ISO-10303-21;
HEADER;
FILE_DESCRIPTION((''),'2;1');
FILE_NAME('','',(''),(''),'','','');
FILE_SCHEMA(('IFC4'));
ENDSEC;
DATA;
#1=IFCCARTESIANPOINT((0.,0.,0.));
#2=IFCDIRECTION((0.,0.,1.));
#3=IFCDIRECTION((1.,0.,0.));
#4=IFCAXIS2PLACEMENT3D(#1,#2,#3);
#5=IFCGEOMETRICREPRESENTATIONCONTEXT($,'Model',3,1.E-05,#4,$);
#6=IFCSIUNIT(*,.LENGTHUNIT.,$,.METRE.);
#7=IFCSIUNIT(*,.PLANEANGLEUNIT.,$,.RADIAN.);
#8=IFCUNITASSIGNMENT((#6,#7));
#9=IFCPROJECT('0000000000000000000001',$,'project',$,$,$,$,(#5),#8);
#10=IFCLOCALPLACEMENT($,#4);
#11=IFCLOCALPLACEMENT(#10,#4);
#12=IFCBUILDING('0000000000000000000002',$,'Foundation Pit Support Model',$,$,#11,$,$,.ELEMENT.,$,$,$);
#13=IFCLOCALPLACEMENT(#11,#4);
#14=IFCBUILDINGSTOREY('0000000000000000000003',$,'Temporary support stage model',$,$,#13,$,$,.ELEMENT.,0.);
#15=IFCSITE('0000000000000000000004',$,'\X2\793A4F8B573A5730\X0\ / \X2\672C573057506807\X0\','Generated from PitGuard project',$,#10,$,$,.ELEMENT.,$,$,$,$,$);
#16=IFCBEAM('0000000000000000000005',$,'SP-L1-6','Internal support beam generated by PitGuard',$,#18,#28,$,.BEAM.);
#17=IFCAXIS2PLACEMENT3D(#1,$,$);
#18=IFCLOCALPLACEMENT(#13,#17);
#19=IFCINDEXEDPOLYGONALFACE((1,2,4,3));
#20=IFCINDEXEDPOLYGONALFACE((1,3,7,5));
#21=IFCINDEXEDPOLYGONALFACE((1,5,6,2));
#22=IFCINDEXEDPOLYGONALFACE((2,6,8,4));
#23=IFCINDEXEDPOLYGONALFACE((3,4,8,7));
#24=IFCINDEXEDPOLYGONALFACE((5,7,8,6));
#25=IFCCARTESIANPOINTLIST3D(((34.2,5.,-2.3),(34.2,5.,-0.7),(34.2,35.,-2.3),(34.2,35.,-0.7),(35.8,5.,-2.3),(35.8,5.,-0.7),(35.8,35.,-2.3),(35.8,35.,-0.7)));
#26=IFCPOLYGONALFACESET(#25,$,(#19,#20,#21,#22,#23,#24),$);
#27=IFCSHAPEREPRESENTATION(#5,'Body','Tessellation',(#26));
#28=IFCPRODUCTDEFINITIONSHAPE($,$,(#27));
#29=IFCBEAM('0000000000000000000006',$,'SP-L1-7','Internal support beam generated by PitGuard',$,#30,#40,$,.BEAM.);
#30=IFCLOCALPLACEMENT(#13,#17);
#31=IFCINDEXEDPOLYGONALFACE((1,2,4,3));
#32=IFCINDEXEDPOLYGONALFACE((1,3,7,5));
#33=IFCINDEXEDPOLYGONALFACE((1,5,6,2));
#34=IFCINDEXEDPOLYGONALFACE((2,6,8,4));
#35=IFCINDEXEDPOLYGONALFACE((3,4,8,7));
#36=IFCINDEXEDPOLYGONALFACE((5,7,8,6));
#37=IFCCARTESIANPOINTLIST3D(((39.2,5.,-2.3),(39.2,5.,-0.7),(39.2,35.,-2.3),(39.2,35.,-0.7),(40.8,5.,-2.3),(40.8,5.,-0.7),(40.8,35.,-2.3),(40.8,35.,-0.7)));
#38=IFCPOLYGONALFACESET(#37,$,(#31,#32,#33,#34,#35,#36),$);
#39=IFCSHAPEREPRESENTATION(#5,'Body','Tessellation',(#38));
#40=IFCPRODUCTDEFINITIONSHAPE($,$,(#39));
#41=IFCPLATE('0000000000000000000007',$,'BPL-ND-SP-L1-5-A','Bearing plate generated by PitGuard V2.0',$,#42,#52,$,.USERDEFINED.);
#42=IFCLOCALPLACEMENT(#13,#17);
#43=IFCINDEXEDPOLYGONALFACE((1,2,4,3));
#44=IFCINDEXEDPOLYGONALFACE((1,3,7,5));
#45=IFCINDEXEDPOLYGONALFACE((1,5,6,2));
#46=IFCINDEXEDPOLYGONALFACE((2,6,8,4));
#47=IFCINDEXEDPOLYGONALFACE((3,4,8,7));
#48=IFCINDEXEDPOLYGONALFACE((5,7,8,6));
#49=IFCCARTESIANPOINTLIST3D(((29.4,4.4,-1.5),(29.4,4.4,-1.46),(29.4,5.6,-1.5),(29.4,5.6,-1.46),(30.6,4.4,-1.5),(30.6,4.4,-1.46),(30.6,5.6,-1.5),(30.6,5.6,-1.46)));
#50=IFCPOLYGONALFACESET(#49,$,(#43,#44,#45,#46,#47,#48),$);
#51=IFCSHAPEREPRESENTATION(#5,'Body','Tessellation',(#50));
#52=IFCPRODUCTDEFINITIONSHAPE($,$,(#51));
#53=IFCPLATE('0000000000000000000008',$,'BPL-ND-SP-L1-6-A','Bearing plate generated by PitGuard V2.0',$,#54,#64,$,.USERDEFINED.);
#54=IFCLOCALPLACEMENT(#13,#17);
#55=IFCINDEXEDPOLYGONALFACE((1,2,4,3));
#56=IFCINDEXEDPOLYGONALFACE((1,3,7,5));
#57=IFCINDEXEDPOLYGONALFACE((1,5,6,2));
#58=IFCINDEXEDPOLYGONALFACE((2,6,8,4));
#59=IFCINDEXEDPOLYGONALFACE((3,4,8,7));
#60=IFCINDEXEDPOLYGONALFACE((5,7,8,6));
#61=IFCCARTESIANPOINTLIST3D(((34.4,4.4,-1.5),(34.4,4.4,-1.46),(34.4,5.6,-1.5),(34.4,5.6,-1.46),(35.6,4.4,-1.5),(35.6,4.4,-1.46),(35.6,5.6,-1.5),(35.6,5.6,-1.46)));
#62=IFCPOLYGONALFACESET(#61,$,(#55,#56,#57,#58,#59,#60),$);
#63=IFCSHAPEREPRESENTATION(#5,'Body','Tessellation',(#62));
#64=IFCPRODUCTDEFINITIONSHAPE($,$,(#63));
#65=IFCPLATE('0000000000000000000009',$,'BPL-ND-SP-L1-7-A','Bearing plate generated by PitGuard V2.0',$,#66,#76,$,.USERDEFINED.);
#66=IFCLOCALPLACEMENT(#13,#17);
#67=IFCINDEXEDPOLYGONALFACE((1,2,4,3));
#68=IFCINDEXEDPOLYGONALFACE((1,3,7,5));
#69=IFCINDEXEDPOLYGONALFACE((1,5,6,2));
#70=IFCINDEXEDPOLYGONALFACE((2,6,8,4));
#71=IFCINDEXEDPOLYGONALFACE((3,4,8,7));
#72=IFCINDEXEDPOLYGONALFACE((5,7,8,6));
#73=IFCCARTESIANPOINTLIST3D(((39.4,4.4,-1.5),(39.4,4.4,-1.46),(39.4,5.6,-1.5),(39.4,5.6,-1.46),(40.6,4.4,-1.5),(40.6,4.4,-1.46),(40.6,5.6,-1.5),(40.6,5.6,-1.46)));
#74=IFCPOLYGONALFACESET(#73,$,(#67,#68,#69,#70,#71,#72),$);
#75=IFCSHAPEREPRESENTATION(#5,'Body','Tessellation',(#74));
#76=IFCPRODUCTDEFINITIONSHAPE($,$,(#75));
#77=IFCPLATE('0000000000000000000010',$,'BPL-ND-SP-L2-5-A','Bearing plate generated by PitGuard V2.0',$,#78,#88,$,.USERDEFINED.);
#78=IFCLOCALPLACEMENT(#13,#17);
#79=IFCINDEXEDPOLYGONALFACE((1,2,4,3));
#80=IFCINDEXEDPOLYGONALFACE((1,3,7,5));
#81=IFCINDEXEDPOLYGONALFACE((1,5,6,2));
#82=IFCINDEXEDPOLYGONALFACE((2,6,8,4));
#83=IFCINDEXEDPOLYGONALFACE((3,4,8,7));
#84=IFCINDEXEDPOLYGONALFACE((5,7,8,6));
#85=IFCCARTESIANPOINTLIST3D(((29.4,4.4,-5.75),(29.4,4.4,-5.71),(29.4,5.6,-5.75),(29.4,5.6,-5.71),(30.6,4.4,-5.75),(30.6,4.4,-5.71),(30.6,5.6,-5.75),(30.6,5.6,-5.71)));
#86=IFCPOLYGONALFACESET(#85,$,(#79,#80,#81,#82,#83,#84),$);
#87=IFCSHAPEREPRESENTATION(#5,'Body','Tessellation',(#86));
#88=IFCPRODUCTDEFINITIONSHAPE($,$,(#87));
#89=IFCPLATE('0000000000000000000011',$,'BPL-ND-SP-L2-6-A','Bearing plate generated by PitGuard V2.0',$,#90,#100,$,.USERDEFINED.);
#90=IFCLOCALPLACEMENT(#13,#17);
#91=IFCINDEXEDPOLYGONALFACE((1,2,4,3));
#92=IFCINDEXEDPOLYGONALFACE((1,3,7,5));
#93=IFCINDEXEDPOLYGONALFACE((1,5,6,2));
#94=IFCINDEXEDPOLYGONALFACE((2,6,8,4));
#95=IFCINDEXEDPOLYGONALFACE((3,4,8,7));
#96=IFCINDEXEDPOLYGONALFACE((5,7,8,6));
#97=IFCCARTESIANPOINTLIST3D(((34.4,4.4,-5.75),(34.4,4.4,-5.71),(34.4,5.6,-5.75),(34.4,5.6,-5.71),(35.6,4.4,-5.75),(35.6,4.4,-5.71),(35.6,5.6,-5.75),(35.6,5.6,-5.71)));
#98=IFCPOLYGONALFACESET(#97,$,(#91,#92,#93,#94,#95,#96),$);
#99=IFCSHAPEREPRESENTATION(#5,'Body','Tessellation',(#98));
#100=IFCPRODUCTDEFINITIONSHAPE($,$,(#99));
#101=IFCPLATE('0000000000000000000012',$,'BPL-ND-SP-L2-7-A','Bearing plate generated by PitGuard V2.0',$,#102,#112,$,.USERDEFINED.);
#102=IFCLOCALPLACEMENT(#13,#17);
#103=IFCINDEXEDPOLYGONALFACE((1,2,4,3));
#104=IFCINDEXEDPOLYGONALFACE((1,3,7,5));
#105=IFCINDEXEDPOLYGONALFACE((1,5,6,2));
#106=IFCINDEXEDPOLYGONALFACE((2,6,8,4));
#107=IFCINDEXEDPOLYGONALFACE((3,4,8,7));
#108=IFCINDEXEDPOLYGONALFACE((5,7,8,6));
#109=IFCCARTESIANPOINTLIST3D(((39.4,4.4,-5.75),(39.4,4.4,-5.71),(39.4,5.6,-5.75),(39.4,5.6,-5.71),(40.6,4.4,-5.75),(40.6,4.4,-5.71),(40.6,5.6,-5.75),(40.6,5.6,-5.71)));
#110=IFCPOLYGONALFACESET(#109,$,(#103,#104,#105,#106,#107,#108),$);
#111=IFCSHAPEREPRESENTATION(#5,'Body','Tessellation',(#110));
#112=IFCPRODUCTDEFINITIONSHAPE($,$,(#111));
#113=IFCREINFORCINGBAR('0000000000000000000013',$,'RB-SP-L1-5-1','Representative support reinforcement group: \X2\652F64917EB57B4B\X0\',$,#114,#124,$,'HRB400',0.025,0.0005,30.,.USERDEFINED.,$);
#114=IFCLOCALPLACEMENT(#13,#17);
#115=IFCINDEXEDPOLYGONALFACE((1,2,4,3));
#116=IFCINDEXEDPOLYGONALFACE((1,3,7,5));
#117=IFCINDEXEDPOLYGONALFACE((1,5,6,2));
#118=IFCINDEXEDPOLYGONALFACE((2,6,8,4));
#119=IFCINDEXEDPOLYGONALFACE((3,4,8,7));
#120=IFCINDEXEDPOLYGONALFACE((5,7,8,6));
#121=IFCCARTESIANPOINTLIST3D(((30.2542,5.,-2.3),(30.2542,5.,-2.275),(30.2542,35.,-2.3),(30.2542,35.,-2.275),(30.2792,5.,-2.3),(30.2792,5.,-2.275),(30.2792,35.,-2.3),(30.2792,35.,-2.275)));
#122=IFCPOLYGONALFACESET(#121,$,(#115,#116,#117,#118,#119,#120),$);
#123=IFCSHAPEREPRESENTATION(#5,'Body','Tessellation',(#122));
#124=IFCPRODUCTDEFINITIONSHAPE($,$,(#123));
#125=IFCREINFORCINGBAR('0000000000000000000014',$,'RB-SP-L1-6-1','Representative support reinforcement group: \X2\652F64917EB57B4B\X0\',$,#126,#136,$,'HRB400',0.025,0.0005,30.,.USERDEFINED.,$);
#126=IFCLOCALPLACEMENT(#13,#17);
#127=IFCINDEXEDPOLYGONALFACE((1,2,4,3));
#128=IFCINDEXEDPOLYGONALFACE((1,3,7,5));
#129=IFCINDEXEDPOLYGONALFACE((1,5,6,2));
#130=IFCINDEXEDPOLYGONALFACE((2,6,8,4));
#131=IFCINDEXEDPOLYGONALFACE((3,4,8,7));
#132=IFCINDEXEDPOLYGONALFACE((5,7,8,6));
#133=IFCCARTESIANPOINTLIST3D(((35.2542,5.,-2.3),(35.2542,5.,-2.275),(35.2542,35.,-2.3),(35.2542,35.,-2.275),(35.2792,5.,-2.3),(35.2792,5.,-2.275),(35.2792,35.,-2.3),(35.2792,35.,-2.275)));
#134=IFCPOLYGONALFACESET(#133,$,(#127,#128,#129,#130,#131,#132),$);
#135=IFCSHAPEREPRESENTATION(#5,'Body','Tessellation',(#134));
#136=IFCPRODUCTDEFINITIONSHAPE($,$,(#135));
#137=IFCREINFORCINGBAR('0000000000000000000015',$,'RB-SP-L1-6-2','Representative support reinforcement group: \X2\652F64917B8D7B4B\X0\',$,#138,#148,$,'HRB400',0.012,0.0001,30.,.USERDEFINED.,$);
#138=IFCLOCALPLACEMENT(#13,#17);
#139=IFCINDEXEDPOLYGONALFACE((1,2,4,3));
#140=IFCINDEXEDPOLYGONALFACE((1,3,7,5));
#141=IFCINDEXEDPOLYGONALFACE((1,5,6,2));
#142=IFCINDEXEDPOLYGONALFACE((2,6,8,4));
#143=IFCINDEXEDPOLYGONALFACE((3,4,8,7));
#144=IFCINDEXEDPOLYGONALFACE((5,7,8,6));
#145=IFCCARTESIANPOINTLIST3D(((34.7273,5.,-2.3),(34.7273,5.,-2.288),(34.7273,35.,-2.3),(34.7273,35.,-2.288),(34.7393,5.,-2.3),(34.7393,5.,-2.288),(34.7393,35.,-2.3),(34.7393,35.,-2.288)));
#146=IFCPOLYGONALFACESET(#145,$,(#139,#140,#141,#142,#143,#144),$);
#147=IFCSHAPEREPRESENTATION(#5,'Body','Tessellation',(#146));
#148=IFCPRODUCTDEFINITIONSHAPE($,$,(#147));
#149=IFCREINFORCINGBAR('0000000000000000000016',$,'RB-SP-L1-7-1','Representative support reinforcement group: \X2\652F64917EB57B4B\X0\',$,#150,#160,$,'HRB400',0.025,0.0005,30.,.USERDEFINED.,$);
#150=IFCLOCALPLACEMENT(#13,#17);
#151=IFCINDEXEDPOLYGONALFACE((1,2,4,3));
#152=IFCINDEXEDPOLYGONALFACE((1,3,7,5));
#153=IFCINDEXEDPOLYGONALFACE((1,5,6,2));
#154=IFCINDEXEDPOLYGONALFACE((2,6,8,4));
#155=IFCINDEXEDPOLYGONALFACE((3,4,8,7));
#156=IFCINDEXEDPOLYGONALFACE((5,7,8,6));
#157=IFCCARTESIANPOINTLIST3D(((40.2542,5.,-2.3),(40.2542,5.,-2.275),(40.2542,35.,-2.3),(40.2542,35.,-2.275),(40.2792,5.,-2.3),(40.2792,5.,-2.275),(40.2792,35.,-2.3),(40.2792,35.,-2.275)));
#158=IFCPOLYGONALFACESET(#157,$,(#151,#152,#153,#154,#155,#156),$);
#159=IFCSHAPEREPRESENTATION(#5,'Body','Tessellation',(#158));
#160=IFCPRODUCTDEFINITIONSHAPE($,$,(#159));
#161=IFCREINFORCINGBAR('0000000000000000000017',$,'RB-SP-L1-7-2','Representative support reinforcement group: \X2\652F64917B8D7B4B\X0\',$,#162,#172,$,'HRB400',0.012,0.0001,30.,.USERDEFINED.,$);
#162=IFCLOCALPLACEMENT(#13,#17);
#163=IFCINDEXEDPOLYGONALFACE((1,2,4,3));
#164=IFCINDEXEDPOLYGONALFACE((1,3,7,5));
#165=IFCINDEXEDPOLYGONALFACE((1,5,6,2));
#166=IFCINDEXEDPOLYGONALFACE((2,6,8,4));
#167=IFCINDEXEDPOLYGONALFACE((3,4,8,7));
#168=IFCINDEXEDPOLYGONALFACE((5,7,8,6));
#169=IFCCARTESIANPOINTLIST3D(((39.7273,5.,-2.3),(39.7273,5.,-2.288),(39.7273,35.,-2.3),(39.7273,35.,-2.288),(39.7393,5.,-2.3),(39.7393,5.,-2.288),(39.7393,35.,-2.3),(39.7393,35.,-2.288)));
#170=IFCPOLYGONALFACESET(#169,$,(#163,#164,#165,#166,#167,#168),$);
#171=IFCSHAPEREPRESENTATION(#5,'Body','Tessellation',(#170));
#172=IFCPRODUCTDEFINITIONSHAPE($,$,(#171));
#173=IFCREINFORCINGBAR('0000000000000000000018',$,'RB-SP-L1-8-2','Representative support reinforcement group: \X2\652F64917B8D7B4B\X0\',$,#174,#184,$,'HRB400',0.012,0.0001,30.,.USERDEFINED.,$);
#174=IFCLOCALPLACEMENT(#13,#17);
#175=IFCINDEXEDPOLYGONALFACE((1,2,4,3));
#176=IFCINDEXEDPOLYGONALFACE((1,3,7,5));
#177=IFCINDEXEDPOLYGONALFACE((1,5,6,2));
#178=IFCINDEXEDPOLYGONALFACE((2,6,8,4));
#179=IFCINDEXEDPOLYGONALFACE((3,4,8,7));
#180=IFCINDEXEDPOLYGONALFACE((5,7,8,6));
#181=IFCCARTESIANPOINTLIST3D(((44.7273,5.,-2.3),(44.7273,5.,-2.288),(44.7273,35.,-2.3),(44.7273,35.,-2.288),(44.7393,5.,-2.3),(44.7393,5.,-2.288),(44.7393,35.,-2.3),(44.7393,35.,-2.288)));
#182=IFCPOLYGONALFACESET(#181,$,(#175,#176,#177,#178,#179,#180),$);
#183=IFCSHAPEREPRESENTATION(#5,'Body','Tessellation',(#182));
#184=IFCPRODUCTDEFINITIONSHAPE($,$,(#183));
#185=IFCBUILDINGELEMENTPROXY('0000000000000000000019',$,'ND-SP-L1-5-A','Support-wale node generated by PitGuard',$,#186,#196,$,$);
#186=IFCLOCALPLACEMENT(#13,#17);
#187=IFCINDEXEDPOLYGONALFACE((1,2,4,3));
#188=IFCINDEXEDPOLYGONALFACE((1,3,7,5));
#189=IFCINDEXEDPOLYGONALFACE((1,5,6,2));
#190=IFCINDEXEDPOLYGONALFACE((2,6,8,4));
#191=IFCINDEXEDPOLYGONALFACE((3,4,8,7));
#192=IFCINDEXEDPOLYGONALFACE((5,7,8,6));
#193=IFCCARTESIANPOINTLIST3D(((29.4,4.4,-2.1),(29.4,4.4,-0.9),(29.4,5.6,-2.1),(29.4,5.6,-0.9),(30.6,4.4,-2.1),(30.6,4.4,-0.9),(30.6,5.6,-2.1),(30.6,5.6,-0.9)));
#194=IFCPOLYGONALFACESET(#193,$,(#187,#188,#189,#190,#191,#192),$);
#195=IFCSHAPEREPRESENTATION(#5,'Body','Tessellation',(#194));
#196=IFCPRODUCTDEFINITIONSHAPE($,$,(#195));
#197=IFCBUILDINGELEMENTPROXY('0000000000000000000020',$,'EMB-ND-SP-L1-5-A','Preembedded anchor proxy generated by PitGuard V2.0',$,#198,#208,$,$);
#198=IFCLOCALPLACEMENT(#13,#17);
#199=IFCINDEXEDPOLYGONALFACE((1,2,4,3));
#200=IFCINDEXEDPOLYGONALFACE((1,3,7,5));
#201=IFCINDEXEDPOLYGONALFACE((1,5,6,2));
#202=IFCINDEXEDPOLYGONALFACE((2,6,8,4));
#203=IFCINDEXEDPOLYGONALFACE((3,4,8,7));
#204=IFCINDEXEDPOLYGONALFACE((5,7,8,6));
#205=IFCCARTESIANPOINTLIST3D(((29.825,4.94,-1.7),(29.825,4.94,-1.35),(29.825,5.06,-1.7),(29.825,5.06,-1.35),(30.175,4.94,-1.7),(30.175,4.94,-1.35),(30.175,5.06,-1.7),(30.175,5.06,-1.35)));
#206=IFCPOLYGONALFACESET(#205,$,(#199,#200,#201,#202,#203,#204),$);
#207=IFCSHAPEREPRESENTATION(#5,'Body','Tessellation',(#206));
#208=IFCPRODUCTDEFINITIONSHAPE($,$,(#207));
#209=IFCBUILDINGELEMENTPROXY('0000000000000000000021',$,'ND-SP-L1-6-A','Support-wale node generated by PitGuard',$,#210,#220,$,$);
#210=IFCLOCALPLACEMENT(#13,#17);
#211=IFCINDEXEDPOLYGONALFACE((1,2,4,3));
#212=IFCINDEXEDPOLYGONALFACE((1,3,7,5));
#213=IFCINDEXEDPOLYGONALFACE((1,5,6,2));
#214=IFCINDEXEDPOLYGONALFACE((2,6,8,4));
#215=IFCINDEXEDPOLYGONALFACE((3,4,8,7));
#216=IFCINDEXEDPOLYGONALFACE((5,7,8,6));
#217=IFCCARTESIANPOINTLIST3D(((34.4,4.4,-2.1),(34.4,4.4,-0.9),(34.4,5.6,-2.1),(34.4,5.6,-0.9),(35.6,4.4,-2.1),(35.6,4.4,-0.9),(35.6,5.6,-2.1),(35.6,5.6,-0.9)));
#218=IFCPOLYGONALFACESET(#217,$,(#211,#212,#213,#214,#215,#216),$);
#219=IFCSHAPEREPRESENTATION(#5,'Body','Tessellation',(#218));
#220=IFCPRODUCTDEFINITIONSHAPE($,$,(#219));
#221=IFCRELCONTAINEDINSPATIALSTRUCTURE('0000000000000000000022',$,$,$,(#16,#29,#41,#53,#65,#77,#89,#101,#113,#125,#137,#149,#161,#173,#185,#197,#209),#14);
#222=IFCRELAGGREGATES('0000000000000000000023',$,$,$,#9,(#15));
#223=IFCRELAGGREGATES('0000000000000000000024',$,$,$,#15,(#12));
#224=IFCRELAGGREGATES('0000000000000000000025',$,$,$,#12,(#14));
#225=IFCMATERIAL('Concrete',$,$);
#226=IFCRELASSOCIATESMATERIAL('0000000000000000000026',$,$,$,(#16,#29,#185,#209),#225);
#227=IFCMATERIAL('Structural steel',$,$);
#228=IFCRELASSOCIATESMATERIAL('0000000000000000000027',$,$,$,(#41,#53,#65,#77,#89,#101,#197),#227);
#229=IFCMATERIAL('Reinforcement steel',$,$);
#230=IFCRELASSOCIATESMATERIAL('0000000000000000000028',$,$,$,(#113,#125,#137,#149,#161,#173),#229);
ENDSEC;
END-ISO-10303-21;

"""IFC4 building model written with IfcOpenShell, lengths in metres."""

from ifc_helpers import new_model, si_unit, frame, origin_with_axes, origin_2d, place, context, project, spatial, rectangle, extrude, material, element, save


model = new_model("IFC4")

# Units and contexts
model_context = context("Model", 3, precision=1e-05, world=origin_with_axes())
ifc_project = project(units=[si_unit("LENGTHUNIT", "METRE"), si_unit("PLANEANGLEUNIT", "RADIAN")], contexts=[model_context])

# Site, building, storey
site_placement = place(None, origin_with_axes())
site = spatial("IfcSite", under=ifc_project, at=site_placement, Name="示例场地 / 本地坐标", Description="Generated from PitGuard project", CompositionType="ELEMENT")
building_placement = place(site_placement, origin_with_axes())
building = spatial("IfcBuilding", under=site, at=building_placement, Name="Foundation Pit Support Model", CompositionType="ELEMENT")
storey_placement = place(building_placement, origin_with_axes())
storey = spatial("IfcBuildingStorey", under=building, at=storey_placement, Name="Temporary support stage model", CompositionType="ELEMENT", Elevation=0.0)

# Beams
ifc_material_1 = material(Name="Concrete")
for number, where, z_axis, x_axis, name in (
    (1, (35.0, 20.0, -2.3), (0.0, 0.0, 1.0), (0.0, 1.0, 0.0), "SP-L1-6"),
    (2, (40.0, 20.0, -2.3), (0.0, 0.0, 1.0), (0.0, 1.0, 0.0), "SP-L1-7"),
):
    element("IfcBeam", number, at=place(storey_placement, frame(where, z_axis=z_axis, x_axis=x_axis)), inside=storey, material=ifc_material_1, Name=name, Description="Internal support beam generated by PitGuard", PredefinedType="BEAM", context=model_context, shape_type="SweptSolid", body=[
        extrude(rectangle(XDim=30.0, YDim=1.6, at=origin_2d()), origin_with_axes(), (0.0, 0.0, 1.0), 1.6),
    ])

# Plates
ifc_material_2 = material(Name="Structural steel")
for number, where, z_axis, x_axis, name in (
    (3, (30.0, 5.0, -1.5), (0.0, 0.0, 1.0), (1.0, 0.0, 0.0), "BPL-ND-SP-L1-5-A"),
    (4, (35.0, 5.0, -1.5), (0.0, 0.0, 1.0), (1.0, 0.0, 0.0), "BPL-ND-SP-L1-6-A"),
    (5, (40.0, 5.0, -1.5), (0.0, 0.0, 1.0), (1.0, 0.0, 0.0), "BPL-ND-SP-L1-7-A"),
    (6, (30.0, 5.0, -5.75), (0.0, 0.0, 1.0), (1.0, 0.0, 0.0), "BPL-ND-SP-L2-5-A"),
    (7, (35.0, 5.0, -5.75), (0.0, 0.0, 1.0), (1.0, 0.0, 0.0), "BPL-ND-SP-L2-6-A"),
    (8, (40.0, 5.0, -5.75), (0.0, 0.0, 1.0), (1.0, 0.0, 0.0), "BPL-ND-SP-L2-7-A"),
):
    element("IfcPlate", number, at=place(storey_placement, frame(where, z_axis=z_axis, x_axis=x_axis)), inside=storey, material=ifc_material_2, Name=name, Description="Bearing plate generated by PitGuard V2.0", PredefinedType="USERDEFINED", context=model_context, shape_type="SweptSolid", body=[
        extrude(rectangle(XDim=1.2, YDim=1.2, at=origin_2d()), origin_with_axes(), (0.0, 0.0, 1.0), 0.04),
    ])

# Reinforcing bars
ifc_material_3 = material(Name="Reinforcement steel")
for number, where, z_axis, x_axis, name in (
    (9, (30.2667, 20.0, -2.3), (0.0, 0.0, 1.0), (0.0, 1.0, 0.0), "RB-SP-L1-5-1"),
    (10, (35.2667, 20.0, -2.3), (0.0, 0.0, 1.0), (0.0, 1.0, 0.0), "RB-SP-L1-6-1"),
):
    element("IfcReinforcingBar", number, at=place(storey_placement, frame(where, z_axis=z_axis, x_axis=x_axis)), inside=storey, material=ifc_material_3, Name=name, Description="Representative support reinforcement group: 支撑纵筋", SteelGrade="HRB400", BarLength=30.0, CrossSectionArea=0.0005, NominalDiameter=0.025, PredefinedType="USERDEFINED", context=model_context, shape_type="SweptSolid", body=[
        extrude(rectangle(XDim=30.0, YDim=0.025, at=origin_2d()), origin_with_axes(), (0.0, 0.0, 1.0), 0.025),
    ])
reinforcing_bar_1_placement = place(storey_placement, frame((34.7333, 20.0, -2.3), z_axis=(0.0, 0.0, 1.0), x_axis=(0.0, 1.0, 0.0)))
element("IfcReinforcingBar", 11, at=reinforcing_bar_1_placement, inside=storey, material=ifc_material_3, Name="RB-SP-L1-6-2", Description="Representative support reinforcement group: 支撑箍筋", SteelGrade="HRB400", BarLength=30.0, CrossSectionArea=0.0001, NominalDiameter=0.012, PredefinedType="USERDEFINED", context=model_context, shape_type="SweptSolid", body=[
    extrude(rectangle(XDim=30.0, YDim=0.012, at=origin_2d()), origin_with_axes(), (0.0, 0.0, 1.0), 0.012),
])
reinforcing_bar_2_placement = place(storey_placement, frame((40.2667, 20.0, -2.3), z_axis=(0.0, 0.0, 1.0), x_axis=(0.0, 1.0, 0.0)))
element("IfcReinforcingBar", 12, at=reinforcing_bar_2_placement, inside=storey, material=ifc_material_3, Name="RB-SP-L1-7-1", Description="Representative support reinforcement group: 支撑纵筋", SteelGrade="HRB400", BarLength=30.0, CrossSectionArea=0.0005, NominalDiameter=0.025, PredefinedType="USERDEFINED", context=model_context, shape_type="SweptSolid", body=[
    extrude(rectangle(XDim=30.0, YDim=0.025, at=origin_2d()), origin_with_axes(), (0.0, 0.0, 1.0), 0.025),
])
for number, where, z_axis, x_axis, name in (
    (13, (39.7333, 20.0, -2.3), (0.0, 0.0, 1.0), (0.0, 1.0, 0.0), "RB-SP-L1-7-2"),
    (14, (44.7333, 20.0, -2.3), (0.0, 0.0, 1.0), (0.0, 1.0, 0.0), "RB-SP-L1-8-2"),
):
    element("IfcReinforcingBar", number, at=place(storey_placement, frame(where, z_axis=z_axis, x_axis=x_axis)), inside=storey, material=ifc_material_3, Name=name, Description="Representative support reinforcement group: 支撑箍筋", SteelGrade="HRB400", BarLength=30.0, CrossSectionArea=0.0001, NominalDiameter=0.012, PredefinedType="USERDEFINED", context=model_context, shape_type="SweptSolid", body=[
        extrude(rectangle(XDim=30.0, YDim=0.012, at=origin_2d()), origin_with_axes(), (0.0, 0.0, 1.0), 0.012),
    ])

# Building element proxies
proxy_1_placement = place(storey_placement, frame((30.0, 5.0, -2.1), z_axis=(0.0, 0.0, 1.0), x_axis=(1.0, 0.0, 0.0)))
element("IfcBuildingElementProxy", 15, at=proxy_1_placement, inside=storey, material=ifc_material_1, Name="ND-SP-L1-5-A", Description="Support-wale node generated by PitGuard", context=model_context, shape_type="SweptSolid", body=[
    extrude(rectangle(XDim=1.2, YDim=1.2, at=origin_2d()), origin_with_axes(), (0.0, 0.0, 1.0), 1.2),
])
proxy_2_placement = place(storey_placement, frame((30.0, 5.0, -1.7), z_axis=(0.0, 0.0, 1.0), x_axis=(1.0, 0.0, 0.0)))
element("IfcBuildingElementProxy", 16, at=proxy_2_placement, inside=storey, material=ifc_material_2, Name="EMB-ND-SP-L1-5-A", Description="Preembedded anchor proxy generated by PitGuard V2.0", context=model_context, shape_type="SweptSolid", body=[
    extrude(rectangle(XDim=0.35, YDim=0.12, at=origin_2d()), origin_with_axes(), (0.0, 0.0, 1.0), 0.35),
])
proxy_3_placement = place(storey_placement, frame((35.0, 5.0, -2.1), z_axis=(0.0, 0.0, 1.0), x_axis=(1.0, 0.0, 0.0)))
element("IfcBuildingElementProxy", 17, at=proxy_3_placement, inside=storey, material=ifc_material_1, Name="ND-SP-L1-6-A", Description="Support-wale node generated by PitGuard", context=model_context, shape_type="SweptSolid", body=[
    extrude(rectangle(XDim=1.2, YDim=1.2, at=origin_2d()), origin_with_axes(), (0.0, 0.0, 1.0), 1.2),
])

save(model, "model.ifc")
